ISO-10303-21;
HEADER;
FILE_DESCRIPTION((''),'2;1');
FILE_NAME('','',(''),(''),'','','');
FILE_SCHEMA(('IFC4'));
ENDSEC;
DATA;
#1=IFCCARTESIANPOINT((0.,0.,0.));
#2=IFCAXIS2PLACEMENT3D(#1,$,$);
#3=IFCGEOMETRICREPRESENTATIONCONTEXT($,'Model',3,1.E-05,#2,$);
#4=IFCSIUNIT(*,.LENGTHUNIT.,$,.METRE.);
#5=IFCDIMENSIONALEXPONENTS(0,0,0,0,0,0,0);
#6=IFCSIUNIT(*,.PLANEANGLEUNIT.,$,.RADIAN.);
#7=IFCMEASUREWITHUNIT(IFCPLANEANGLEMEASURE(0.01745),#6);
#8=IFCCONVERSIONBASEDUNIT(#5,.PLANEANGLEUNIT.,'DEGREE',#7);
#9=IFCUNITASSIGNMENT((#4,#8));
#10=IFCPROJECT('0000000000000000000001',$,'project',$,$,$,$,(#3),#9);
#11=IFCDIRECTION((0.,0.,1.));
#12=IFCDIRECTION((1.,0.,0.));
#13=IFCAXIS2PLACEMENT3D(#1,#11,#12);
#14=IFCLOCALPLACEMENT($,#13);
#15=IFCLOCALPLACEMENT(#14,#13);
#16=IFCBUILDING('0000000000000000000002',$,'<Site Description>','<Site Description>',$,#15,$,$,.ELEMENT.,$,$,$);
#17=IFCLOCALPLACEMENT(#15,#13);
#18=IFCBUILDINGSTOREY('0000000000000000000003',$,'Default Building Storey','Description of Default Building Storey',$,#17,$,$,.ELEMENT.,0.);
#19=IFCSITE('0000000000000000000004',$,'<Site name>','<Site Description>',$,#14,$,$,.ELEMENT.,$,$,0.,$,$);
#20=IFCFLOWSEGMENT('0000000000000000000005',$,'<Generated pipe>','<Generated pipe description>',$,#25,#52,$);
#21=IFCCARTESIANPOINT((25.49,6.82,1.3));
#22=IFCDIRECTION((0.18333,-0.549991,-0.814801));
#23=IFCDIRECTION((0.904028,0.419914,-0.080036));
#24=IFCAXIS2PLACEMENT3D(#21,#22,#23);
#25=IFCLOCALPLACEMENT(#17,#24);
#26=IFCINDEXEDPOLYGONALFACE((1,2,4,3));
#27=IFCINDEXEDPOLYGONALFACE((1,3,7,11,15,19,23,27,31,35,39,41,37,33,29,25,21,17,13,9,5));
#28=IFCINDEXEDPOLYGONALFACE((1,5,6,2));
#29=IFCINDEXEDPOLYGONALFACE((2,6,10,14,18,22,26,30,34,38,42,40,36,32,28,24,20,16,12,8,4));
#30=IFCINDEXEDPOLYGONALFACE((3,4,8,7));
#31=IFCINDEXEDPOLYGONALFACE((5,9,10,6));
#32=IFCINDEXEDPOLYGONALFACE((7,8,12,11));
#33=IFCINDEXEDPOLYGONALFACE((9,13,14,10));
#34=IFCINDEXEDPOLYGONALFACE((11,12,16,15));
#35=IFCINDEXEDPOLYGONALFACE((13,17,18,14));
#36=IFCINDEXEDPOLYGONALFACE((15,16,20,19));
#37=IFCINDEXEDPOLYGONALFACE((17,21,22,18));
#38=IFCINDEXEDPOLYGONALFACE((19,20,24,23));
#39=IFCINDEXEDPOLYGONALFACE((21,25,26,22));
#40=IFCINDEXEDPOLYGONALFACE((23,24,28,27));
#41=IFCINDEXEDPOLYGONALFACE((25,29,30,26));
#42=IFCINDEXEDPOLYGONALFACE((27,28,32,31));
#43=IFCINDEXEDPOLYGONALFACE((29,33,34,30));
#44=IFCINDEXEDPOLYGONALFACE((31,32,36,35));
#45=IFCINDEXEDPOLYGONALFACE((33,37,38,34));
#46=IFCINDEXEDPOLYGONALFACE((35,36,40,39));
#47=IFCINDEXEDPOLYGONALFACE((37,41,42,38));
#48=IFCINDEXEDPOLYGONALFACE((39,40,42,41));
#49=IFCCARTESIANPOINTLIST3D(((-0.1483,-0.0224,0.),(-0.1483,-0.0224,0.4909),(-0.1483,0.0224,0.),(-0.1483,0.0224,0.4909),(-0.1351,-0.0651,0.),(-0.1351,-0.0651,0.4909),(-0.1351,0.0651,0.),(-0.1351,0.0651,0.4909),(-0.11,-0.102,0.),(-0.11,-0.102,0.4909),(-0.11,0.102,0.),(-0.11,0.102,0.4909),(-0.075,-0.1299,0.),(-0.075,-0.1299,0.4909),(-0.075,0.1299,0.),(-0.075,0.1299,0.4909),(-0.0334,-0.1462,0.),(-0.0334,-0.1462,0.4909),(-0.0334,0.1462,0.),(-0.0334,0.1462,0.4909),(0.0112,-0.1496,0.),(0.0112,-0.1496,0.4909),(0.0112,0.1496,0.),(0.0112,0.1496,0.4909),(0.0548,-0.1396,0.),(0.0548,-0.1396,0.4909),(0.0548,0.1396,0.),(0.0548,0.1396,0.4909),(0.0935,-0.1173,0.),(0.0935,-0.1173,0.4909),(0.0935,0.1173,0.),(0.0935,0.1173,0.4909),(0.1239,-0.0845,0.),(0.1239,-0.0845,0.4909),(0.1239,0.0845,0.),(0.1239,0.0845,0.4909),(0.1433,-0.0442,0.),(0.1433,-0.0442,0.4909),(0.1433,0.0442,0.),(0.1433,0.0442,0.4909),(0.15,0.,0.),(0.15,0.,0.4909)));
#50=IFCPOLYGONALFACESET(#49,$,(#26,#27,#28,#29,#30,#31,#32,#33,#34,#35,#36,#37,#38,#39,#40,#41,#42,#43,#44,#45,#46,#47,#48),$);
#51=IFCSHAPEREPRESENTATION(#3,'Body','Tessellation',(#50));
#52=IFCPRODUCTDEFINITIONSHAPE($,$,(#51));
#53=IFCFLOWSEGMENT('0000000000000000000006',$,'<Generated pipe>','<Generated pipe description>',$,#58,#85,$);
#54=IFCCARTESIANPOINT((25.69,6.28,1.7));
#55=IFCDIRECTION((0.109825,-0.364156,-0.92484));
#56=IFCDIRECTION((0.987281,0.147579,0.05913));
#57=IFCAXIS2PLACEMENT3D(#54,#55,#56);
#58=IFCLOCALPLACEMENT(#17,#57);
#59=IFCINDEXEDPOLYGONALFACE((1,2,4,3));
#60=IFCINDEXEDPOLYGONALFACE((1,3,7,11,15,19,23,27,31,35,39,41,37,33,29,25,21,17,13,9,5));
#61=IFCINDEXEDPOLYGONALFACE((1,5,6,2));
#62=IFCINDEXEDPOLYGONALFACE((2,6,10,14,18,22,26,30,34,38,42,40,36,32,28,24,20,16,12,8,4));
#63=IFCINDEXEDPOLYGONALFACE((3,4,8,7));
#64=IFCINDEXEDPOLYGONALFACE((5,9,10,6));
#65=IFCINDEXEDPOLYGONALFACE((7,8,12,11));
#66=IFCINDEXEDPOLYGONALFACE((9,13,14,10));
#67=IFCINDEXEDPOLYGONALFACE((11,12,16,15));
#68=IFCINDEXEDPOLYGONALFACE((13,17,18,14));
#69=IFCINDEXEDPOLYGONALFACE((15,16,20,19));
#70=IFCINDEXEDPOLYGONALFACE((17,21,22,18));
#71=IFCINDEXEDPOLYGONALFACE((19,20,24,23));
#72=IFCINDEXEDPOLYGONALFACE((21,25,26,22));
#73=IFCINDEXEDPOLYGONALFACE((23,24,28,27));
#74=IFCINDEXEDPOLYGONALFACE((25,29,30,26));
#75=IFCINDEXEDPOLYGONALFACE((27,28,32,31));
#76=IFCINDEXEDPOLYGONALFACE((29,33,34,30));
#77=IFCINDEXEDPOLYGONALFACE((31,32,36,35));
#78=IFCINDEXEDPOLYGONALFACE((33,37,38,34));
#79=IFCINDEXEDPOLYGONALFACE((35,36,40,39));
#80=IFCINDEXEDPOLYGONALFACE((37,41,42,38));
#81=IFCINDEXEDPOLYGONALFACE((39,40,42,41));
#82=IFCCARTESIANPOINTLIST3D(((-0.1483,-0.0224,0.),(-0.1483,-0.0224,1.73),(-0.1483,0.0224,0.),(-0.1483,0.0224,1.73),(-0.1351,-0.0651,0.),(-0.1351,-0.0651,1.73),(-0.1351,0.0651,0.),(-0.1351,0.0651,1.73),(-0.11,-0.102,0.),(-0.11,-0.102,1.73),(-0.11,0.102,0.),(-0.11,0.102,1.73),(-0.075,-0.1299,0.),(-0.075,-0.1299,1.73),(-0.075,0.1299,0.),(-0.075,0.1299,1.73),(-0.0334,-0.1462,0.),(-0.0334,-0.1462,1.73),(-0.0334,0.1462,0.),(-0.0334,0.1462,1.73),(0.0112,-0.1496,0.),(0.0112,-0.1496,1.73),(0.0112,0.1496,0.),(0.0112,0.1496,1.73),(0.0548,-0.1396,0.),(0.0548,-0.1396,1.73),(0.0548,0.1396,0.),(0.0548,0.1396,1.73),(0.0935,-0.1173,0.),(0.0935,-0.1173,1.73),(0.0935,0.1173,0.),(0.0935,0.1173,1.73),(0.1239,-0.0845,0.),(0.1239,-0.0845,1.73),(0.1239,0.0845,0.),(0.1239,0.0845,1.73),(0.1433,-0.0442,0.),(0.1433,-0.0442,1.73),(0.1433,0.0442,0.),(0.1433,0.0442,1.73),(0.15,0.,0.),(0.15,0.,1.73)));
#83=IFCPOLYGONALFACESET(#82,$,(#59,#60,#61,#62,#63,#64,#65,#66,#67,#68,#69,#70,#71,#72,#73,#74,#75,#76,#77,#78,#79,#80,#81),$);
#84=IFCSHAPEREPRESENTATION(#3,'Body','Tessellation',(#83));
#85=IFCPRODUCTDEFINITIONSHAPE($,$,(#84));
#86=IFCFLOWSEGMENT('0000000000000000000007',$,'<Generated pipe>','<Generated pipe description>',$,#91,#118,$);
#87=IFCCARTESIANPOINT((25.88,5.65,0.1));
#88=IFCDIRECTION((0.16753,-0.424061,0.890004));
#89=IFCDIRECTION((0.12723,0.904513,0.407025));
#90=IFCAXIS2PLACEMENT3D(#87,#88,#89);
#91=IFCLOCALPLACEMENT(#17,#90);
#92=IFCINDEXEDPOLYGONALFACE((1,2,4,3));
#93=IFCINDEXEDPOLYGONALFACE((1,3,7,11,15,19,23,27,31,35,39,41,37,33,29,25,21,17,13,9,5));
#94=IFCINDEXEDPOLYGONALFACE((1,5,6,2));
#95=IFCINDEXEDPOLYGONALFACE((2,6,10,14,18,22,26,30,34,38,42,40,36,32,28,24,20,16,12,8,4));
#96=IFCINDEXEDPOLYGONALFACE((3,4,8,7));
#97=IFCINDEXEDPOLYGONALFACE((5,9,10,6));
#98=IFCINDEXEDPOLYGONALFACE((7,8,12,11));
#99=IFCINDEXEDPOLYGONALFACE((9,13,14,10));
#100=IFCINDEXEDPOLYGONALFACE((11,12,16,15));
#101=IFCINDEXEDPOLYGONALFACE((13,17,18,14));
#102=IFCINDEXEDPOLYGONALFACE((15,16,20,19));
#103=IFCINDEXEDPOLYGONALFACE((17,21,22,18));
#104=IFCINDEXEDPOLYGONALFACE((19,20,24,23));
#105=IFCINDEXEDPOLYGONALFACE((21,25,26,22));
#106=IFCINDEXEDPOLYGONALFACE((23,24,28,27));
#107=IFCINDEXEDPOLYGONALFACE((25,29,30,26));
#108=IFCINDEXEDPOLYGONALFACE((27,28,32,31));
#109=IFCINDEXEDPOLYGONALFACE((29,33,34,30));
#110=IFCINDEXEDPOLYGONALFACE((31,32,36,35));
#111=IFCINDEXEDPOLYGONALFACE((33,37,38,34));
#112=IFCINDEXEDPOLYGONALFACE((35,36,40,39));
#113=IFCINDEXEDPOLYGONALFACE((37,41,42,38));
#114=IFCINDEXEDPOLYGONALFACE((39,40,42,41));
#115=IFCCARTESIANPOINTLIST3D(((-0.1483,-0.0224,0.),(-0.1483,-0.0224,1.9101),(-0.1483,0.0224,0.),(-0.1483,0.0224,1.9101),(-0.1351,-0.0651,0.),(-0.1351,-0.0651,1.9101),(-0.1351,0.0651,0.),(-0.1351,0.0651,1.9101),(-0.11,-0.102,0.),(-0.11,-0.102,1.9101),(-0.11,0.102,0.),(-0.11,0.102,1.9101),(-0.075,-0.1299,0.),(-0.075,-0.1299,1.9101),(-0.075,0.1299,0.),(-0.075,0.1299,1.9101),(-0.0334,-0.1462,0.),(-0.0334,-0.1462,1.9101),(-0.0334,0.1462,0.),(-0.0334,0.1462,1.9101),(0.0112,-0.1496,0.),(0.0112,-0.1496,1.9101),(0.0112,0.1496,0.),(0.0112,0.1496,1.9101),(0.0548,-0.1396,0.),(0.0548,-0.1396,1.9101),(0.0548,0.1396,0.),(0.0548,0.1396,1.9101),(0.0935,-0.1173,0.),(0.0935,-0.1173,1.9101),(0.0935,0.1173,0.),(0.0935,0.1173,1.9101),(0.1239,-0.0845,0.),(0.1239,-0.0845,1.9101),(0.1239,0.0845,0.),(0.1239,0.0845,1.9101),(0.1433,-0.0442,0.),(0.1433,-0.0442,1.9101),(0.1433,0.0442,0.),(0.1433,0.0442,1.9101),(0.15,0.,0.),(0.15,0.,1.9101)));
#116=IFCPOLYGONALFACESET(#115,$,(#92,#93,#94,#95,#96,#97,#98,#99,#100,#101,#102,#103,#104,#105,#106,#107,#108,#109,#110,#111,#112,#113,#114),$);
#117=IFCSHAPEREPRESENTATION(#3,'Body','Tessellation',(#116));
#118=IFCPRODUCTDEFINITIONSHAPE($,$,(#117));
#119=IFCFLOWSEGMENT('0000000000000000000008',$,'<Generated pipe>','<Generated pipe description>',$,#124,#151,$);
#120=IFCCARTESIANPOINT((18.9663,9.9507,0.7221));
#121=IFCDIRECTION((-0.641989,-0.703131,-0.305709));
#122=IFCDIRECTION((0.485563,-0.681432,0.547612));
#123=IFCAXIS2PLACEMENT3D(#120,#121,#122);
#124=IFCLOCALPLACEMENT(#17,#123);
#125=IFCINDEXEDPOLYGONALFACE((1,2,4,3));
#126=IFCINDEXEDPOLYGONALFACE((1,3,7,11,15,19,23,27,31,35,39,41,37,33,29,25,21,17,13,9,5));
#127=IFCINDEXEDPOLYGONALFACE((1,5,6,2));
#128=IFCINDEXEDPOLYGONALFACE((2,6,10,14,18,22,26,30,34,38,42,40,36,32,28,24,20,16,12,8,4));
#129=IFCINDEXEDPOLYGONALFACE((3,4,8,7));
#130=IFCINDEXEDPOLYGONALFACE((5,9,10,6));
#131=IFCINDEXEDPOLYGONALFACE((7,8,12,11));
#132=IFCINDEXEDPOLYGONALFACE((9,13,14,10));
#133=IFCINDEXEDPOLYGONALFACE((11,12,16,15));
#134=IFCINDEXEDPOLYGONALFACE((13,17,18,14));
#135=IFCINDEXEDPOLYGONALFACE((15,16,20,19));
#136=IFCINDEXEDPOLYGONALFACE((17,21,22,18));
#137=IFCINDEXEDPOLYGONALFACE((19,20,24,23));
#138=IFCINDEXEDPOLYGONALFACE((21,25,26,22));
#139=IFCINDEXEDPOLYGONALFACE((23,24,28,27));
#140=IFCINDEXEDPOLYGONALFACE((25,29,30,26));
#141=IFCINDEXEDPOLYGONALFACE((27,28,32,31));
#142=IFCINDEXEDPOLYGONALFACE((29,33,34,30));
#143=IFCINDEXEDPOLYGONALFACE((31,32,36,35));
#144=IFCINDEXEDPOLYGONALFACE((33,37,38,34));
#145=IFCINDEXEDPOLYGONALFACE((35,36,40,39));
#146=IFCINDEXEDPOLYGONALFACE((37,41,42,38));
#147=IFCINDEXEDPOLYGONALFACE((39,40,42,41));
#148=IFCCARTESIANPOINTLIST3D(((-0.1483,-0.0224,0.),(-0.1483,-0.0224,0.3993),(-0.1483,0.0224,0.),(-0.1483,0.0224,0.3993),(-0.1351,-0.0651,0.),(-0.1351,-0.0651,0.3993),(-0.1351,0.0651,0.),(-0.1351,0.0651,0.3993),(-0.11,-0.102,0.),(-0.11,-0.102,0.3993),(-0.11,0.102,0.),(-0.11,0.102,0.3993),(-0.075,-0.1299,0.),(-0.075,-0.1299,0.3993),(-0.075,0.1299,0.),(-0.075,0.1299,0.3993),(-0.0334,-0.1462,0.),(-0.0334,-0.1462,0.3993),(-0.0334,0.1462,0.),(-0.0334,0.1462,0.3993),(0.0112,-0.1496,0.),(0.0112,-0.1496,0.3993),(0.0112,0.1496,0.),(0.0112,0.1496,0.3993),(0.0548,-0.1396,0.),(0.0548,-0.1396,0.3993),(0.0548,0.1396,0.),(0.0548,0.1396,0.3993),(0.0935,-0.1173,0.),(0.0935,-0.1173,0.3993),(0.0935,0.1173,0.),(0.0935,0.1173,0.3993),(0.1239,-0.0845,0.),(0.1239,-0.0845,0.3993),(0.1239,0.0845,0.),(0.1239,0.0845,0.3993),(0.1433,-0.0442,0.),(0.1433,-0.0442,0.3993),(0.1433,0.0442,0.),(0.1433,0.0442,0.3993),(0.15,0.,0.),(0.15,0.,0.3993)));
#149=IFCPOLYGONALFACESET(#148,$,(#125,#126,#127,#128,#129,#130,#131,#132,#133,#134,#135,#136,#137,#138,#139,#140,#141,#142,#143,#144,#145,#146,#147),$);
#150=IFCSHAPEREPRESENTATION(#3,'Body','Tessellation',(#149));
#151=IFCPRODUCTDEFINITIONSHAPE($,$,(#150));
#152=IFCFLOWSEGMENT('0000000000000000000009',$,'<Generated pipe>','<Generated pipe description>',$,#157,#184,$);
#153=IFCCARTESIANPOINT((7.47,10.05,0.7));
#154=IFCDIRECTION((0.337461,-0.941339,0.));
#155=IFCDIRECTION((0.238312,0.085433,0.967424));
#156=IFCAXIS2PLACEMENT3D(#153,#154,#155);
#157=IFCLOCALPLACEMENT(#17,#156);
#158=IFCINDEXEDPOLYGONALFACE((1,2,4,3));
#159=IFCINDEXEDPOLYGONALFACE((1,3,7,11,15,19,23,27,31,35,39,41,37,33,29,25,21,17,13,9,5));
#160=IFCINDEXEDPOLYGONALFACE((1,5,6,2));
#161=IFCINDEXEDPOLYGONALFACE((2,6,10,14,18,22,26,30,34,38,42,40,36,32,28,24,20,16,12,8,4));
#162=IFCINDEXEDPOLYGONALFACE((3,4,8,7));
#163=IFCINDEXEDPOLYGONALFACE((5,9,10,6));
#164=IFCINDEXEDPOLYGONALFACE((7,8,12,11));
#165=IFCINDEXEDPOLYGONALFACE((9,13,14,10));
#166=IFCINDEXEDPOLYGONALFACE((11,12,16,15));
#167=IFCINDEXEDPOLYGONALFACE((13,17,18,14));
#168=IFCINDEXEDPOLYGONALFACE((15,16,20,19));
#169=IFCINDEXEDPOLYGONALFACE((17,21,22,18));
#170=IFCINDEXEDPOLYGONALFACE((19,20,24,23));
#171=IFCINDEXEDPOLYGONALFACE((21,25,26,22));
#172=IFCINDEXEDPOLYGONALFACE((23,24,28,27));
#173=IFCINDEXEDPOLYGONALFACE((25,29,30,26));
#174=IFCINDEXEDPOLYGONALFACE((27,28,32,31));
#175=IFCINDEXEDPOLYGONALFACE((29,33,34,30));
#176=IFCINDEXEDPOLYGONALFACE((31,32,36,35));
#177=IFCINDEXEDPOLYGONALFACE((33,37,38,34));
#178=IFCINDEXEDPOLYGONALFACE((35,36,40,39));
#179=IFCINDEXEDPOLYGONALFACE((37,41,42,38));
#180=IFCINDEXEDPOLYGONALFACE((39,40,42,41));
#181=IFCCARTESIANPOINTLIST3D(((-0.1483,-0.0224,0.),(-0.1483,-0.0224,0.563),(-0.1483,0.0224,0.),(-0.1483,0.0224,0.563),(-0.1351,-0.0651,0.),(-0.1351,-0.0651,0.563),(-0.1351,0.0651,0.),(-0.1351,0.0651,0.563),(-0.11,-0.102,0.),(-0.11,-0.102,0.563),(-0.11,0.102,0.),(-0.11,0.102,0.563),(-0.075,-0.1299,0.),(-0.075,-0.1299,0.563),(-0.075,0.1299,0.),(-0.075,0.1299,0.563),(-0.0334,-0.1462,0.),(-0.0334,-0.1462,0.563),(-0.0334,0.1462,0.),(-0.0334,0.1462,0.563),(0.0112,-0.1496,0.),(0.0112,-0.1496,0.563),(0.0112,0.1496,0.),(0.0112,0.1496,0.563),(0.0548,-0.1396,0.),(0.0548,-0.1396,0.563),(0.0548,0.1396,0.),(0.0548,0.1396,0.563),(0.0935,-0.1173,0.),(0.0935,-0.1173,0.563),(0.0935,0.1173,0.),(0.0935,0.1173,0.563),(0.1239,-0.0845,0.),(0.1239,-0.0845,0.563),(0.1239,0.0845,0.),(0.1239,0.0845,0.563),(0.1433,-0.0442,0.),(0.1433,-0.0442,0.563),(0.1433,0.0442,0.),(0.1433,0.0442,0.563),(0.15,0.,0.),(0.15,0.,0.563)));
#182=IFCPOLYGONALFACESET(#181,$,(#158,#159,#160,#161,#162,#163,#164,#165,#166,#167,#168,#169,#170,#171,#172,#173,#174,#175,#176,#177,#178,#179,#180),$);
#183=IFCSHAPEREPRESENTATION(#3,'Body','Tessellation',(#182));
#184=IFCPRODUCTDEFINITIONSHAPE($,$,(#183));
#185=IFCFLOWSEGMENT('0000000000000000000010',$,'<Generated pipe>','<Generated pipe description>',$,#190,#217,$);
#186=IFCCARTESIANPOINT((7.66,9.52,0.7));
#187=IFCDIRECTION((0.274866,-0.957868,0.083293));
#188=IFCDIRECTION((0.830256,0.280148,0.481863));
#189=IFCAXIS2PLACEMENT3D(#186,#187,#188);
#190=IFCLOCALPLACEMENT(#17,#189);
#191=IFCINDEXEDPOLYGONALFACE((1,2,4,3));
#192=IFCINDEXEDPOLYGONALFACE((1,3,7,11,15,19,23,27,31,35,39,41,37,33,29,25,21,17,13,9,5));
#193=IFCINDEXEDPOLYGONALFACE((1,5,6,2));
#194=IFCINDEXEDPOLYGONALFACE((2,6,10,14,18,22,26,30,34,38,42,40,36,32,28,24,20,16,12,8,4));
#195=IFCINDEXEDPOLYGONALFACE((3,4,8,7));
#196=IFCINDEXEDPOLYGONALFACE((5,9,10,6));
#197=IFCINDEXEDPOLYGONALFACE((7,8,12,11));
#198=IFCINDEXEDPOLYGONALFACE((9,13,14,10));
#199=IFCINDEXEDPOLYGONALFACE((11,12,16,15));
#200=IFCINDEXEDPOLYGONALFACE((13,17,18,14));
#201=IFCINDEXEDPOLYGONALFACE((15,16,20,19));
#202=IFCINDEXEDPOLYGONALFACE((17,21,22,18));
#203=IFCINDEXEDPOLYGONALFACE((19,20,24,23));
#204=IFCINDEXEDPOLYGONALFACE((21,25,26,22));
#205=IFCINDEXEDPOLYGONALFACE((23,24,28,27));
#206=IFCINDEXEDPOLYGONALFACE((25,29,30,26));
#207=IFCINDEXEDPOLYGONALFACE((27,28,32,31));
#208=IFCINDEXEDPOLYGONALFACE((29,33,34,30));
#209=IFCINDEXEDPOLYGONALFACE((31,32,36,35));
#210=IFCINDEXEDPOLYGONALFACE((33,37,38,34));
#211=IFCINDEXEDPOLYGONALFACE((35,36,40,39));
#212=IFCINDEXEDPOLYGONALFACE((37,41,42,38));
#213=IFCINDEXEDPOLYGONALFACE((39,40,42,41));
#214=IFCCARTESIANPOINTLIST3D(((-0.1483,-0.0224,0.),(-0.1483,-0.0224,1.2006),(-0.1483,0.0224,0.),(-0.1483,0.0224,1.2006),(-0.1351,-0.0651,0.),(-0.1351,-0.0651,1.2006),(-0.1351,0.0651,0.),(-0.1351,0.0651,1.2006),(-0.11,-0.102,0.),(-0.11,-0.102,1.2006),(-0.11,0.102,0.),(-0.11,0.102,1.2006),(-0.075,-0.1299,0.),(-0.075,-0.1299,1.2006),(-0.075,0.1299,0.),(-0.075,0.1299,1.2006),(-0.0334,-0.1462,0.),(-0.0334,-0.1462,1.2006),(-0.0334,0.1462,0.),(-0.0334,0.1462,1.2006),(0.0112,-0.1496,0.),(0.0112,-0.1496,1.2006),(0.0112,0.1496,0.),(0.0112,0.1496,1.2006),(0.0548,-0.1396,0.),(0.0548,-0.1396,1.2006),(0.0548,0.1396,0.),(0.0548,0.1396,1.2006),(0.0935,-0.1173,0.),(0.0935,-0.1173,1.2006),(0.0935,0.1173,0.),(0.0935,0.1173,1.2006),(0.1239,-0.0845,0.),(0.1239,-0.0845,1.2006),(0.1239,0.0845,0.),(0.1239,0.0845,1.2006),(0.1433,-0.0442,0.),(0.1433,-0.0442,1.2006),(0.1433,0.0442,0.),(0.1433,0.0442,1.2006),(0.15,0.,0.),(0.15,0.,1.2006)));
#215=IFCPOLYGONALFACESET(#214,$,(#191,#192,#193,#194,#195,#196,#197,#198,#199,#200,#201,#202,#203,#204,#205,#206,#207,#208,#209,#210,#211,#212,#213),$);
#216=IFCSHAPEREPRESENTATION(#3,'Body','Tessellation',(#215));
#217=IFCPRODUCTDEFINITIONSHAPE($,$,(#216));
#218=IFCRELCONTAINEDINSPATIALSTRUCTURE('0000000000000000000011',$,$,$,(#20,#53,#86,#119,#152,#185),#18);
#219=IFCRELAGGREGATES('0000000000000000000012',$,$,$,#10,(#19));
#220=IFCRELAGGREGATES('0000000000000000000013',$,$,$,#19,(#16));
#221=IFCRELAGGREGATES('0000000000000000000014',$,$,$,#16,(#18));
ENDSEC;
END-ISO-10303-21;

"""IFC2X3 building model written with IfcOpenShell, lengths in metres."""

from ifc_helpers import new_model, entity, si_unit, converted_unit, frame, origin, origin_with_axes, origin_2d_with_axis, place, context, project, spatial, circle, extrude, element, save


model = new_model("IFC2X3")

# Units and contexts
model_context = context("Model", 3, precision=1e-05, world=origin())
ifc_project = project(units=[si_unit("LENGTHUNIT", "METRE"), converted_unit("PLANEANGLEUNIT", "DEGREE", entity("IfcPlaneAngleMeasure", 0.01745), si_unit("PLANEANGLEUNIT", "RADIAN"), dimensions=[0, 0, 0, 0, 0, 0, 0])], contexts=[model_context])

# Site, building, storey
site_placement = place(None, origin_with_axes())
site = spatial("IfcSite", under=ifc_project, at=site_placement, Name="<Site name>", Description="<Site Description>", CompositionType="ELEMENT", RefElevation=0.0)
building_placement = place(site_placement, origin_with_axes())
building = spatial("IfcBuilding", under=site, at=building_placement, Name="<Site Description>", Description="<Site Description>", CompositionType="ELEMENT")
storey_placement = place(building_placement, origin_with_axes())
storey = spatial("IfcBuildingStorey", under=building, at=storey_placement, Name="Default Building Storey", Description="Description of Default Building Storey", CompositionType="ELEMENT", Elevation=0.0)

# Flow segments
flow_segment_1_placement = place(storey_placement, frame((25.49, 6.82, 1.3), z_axis=(0.18333, -0.549991, -0.814801), x_axis=(0.904028, 0.419914, -0.080036)))
element("IfcFlowSegment", 1, at=flow_segment_1_placement, inside=storey, Name="<Generated pipe>", Description="<Generated pipe description>", context=model_context, shape_type="SweptSolid", body=[
    extrude(circle(Radius=0.15, at=origin_2d_with_axis()), origin_with_axes(), (0.0, 0.0, 1.0), 0.4909),
])
flow_segment_2_placement = place(storey_placement, frame((25.69, 6.28, 1.7), z_axis=(0.109825, -0.364156, -0.92484), x_axis=(0.987281, 0.147579, 0.05913)))
element("IfcFlowSegment", 2, at=flow_segment_2_placement, inside=storey, Name="<Generated pipe>", Description="<Generated pipe description>", context=model_context, shape_type="SweptSolid", body=[
    extrude(circle(Radius=0.15, at=origin_2d_with_axis()), origin_with_axes(), (0.0, 0.0, 1.0), 1.73),
])
flow_segment_3_placement = place(storey_placement, frame((25.88, 5.65, 0.1), z_axis=(0.16753, -0.424061, 0.890004), x_axis=(0.12723, 0.904513, 0.407025)))
element("IfcFlowSegment", 3, at=flow_segment_3_placement, inside=storey, Name="<Generated pipe>", Description="<Generated pipe description>", context=model_context, shape_type="SweptSolid", body=[
    extrude(circle(Radius=0.15, at=origin_2d_with_axis()), origin_with_axes(), (0.0, 0.0, 1.0), 1.9101),
])
flow_segment_4_placement = place(storey_placement, frame((18.9663, 9.9507, 0.7221), z_axis=(-0.641989, -0.703131, -0.305709), x_axis=(0.485563, -0.681432, 0.547612)))
element("IfcFlowSegment", 4, at=flow_segment_4_placement, inside=storey, Name="<Generated pipe>", Description="<Generated pipe description>", context=model_context, shape_type="SweptSolid", body=[
    extrude(circle(Radius=0.15, at=origin_2d_with_axis()), origin_with_axes(), (0.0, 0.0, 1.0), 0.3993),
])
flow_segment_5_placement = place(storey_placement, frame((7.47, 10.05, 0.7), z_axis=(0.337461, -0.941339, 0.0), x_axis=(0.238312, 0.085433, 0.967424)))
element("IfcFlowSegment", 5, at=flow_segment_5_placement, inside=storey, Name="<Generated pipe>", Description="<Generated pipe description>", context=model_context, shape_type="SweptSolid", body=[
    extrude(circle(Radius=0.15, at=origin_2d_with_axis()), origin_with_axes(), (0.0, 0.0, 1.0), 0.563),
])
flow_segment_6_placement = place(storey_placement, frame((7.66, 9.52, 0.7), z_axis=(0.274866, -0.957868, 0.083293), x_axis=(0.830256, 0.280148, 0.481863)))
element("IfcFlowSegment", 6, at=flow_segment_6_placement, inside=storey, Name="<Generated pipe>", Description="<Generated pipe description>", context=model_context, shape_type="SweptSolid", body=[
    extrude(circle(Radius=0.15, at=origin_2d_with_axis()), origin_with_axes(), (0.0, 0.0, 1.0), 1.2006),
])

save(model, "model.ifc")
